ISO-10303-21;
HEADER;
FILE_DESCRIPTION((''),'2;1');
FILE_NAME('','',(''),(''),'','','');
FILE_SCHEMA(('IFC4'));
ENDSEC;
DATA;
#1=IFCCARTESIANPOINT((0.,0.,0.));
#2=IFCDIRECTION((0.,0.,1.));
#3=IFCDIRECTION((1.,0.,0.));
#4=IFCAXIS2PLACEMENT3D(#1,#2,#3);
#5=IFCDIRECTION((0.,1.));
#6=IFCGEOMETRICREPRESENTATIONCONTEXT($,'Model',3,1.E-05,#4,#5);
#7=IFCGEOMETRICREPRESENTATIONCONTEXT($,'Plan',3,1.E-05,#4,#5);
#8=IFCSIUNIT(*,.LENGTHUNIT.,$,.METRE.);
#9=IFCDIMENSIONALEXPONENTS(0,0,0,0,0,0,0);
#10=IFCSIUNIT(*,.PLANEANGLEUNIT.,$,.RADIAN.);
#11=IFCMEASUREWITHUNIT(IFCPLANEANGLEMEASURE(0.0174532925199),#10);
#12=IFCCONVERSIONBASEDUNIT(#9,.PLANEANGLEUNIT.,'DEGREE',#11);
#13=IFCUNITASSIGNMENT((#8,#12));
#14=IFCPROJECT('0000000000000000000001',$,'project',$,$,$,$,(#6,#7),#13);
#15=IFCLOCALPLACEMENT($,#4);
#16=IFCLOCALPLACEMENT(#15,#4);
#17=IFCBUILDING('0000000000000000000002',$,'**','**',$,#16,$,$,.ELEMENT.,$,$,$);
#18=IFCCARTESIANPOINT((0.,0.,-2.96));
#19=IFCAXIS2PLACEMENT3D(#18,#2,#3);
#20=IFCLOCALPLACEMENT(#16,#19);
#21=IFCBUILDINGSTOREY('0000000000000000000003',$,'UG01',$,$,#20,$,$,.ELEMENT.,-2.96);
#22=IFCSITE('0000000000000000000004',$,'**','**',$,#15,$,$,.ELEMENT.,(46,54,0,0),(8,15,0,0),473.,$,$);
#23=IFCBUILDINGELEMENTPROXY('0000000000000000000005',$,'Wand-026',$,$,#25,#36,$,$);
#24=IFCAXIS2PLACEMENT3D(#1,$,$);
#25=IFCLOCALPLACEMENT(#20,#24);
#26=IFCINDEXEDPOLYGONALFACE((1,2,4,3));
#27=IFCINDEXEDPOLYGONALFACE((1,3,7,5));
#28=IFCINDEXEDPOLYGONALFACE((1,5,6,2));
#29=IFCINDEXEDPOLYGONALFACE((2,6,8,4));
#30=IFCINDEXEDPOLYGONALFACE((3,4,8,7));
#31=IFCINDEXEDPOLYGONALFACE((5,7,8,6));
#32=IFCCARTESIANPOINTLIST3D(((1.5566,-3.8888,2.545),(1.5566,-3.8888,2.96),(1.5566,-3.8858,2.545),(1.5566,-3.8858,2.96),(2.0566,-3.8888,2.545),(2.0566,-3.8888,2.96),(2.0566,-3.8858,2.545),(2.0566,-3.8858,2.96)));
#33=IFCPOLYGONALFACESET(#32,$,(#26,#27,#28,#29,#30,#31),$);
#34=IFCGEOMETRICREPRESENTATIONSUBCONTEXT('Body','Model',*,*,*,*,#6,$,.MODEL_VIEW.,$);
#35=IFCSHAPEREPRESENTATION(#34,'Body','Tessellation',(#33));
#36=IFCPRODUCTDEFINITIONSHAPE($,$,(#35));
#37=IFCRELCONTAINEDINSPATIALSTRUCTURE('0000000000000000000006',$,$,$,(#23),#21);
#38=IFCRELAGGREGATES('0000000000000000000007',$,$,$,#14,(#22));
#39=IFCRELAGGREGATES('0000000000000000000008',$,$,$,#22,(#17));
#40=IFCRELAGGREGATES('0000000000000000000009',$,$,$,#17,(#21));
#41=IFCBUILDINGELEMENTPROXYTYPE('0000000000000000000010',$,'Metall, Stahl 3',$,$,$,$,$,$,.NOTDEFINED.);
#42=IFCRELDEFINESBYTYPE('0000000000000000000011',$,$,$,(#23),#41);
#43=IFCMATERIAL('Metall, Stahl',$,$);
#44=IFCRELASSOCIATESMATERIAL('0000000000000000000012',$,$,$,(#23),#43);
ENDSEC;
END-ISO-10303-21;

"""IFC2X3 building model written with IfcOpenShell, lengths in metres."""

from ifc_helpers import new_model, entity, si_unit, converted_unit, direction, frame, origin_with_axes, place, context, subcontext, project, spatial, polyline, outline, extrude, material, type_object, element, save


model = new_model("IFC2X3")

# Units and contexts
model_context = context("Model", 3, precision=1e-05, world=origin_with_axes(), true_north=direction((0.0, 1.0)))
plan_context = context("Plan", 3, precision=1e-05, world=origin_with_axes(), true_north=direction((0.0, 1.0)))
body_context = subcontext(model_context, "Body", "Model", "MODEL_VIEW")
ifc_project = project(units=[si_unit("LENGTHUNIT", "METRE"), converted_unit("PLANEANGLEUNIT", "DEGREE", entity("IfcPlaneAngleMeasure", 0.0174532925199), si_unit("PLANEANGLEUNIT", "RADIAN"), dimensions=[0, 0, 0, 0, 0, 0, 0])], contexts=[model_context, plan_context])

# Site, building, storey
site_placement = place(None, origin_with_axes())
site = spatial("IfcSite", under=ifc_project, at=site_placement, Name="**", Description="**", CompositionType="ELEMENT", RefLatitude=(46, 54, 0, 0), RefLongitude=(8, 15, 0, 0), RefElevation=473.0)
building_placement = place(site_placement, origin_with_axes())
building = spatial("IfcBuilding", under=site, at=building_placement, Name="**", Description="**", CompositionType="ELEMENT")
storey_placement = place(building_placement, frame((0.0, 0.0, -2.96), z_axis=(0.0, 0.0, 1.0), x_axis=(1.0, 0.0, 0.0)))
storey = spatial("IfcBuildingStorey", under=building, at=storey_placement, Name="UG01", CompositionType="ELEMENT", Elevation=-2.96)

# Building element proxy
ifc_material = material(Name="Metall, Stahl")
building_element_proxy_type = type_object("IfcBuildingElementProxyType", Name="Metall, Stahl 3", PredefinedType="NOTDEFINED")
proxy_placement = place(storey_placement, frame((1.5566, -3.8888, 2.545), z_axis=(0.0, 0.0, 1.0), x_axis=(1.0, 0.0, 0.0)))
element("IfcBuildingElementProxy", 1, at=proxy_placement, inside=storey, type_object=building_element_proxy_type, material=ifc_material, Name="Wand-026", context=body_context, shape_type="SweptSolid", body=[
    extrude(outline(polyline([(0.0, 0.0), (0.5, 0.0), (0.5, 0.003), (0.0, 0.003), (0.0, 0.0)])), origin_with_axes(), (0.0, 0.0, 1.0), 0.415),
])

save(model, "model.ifc")
